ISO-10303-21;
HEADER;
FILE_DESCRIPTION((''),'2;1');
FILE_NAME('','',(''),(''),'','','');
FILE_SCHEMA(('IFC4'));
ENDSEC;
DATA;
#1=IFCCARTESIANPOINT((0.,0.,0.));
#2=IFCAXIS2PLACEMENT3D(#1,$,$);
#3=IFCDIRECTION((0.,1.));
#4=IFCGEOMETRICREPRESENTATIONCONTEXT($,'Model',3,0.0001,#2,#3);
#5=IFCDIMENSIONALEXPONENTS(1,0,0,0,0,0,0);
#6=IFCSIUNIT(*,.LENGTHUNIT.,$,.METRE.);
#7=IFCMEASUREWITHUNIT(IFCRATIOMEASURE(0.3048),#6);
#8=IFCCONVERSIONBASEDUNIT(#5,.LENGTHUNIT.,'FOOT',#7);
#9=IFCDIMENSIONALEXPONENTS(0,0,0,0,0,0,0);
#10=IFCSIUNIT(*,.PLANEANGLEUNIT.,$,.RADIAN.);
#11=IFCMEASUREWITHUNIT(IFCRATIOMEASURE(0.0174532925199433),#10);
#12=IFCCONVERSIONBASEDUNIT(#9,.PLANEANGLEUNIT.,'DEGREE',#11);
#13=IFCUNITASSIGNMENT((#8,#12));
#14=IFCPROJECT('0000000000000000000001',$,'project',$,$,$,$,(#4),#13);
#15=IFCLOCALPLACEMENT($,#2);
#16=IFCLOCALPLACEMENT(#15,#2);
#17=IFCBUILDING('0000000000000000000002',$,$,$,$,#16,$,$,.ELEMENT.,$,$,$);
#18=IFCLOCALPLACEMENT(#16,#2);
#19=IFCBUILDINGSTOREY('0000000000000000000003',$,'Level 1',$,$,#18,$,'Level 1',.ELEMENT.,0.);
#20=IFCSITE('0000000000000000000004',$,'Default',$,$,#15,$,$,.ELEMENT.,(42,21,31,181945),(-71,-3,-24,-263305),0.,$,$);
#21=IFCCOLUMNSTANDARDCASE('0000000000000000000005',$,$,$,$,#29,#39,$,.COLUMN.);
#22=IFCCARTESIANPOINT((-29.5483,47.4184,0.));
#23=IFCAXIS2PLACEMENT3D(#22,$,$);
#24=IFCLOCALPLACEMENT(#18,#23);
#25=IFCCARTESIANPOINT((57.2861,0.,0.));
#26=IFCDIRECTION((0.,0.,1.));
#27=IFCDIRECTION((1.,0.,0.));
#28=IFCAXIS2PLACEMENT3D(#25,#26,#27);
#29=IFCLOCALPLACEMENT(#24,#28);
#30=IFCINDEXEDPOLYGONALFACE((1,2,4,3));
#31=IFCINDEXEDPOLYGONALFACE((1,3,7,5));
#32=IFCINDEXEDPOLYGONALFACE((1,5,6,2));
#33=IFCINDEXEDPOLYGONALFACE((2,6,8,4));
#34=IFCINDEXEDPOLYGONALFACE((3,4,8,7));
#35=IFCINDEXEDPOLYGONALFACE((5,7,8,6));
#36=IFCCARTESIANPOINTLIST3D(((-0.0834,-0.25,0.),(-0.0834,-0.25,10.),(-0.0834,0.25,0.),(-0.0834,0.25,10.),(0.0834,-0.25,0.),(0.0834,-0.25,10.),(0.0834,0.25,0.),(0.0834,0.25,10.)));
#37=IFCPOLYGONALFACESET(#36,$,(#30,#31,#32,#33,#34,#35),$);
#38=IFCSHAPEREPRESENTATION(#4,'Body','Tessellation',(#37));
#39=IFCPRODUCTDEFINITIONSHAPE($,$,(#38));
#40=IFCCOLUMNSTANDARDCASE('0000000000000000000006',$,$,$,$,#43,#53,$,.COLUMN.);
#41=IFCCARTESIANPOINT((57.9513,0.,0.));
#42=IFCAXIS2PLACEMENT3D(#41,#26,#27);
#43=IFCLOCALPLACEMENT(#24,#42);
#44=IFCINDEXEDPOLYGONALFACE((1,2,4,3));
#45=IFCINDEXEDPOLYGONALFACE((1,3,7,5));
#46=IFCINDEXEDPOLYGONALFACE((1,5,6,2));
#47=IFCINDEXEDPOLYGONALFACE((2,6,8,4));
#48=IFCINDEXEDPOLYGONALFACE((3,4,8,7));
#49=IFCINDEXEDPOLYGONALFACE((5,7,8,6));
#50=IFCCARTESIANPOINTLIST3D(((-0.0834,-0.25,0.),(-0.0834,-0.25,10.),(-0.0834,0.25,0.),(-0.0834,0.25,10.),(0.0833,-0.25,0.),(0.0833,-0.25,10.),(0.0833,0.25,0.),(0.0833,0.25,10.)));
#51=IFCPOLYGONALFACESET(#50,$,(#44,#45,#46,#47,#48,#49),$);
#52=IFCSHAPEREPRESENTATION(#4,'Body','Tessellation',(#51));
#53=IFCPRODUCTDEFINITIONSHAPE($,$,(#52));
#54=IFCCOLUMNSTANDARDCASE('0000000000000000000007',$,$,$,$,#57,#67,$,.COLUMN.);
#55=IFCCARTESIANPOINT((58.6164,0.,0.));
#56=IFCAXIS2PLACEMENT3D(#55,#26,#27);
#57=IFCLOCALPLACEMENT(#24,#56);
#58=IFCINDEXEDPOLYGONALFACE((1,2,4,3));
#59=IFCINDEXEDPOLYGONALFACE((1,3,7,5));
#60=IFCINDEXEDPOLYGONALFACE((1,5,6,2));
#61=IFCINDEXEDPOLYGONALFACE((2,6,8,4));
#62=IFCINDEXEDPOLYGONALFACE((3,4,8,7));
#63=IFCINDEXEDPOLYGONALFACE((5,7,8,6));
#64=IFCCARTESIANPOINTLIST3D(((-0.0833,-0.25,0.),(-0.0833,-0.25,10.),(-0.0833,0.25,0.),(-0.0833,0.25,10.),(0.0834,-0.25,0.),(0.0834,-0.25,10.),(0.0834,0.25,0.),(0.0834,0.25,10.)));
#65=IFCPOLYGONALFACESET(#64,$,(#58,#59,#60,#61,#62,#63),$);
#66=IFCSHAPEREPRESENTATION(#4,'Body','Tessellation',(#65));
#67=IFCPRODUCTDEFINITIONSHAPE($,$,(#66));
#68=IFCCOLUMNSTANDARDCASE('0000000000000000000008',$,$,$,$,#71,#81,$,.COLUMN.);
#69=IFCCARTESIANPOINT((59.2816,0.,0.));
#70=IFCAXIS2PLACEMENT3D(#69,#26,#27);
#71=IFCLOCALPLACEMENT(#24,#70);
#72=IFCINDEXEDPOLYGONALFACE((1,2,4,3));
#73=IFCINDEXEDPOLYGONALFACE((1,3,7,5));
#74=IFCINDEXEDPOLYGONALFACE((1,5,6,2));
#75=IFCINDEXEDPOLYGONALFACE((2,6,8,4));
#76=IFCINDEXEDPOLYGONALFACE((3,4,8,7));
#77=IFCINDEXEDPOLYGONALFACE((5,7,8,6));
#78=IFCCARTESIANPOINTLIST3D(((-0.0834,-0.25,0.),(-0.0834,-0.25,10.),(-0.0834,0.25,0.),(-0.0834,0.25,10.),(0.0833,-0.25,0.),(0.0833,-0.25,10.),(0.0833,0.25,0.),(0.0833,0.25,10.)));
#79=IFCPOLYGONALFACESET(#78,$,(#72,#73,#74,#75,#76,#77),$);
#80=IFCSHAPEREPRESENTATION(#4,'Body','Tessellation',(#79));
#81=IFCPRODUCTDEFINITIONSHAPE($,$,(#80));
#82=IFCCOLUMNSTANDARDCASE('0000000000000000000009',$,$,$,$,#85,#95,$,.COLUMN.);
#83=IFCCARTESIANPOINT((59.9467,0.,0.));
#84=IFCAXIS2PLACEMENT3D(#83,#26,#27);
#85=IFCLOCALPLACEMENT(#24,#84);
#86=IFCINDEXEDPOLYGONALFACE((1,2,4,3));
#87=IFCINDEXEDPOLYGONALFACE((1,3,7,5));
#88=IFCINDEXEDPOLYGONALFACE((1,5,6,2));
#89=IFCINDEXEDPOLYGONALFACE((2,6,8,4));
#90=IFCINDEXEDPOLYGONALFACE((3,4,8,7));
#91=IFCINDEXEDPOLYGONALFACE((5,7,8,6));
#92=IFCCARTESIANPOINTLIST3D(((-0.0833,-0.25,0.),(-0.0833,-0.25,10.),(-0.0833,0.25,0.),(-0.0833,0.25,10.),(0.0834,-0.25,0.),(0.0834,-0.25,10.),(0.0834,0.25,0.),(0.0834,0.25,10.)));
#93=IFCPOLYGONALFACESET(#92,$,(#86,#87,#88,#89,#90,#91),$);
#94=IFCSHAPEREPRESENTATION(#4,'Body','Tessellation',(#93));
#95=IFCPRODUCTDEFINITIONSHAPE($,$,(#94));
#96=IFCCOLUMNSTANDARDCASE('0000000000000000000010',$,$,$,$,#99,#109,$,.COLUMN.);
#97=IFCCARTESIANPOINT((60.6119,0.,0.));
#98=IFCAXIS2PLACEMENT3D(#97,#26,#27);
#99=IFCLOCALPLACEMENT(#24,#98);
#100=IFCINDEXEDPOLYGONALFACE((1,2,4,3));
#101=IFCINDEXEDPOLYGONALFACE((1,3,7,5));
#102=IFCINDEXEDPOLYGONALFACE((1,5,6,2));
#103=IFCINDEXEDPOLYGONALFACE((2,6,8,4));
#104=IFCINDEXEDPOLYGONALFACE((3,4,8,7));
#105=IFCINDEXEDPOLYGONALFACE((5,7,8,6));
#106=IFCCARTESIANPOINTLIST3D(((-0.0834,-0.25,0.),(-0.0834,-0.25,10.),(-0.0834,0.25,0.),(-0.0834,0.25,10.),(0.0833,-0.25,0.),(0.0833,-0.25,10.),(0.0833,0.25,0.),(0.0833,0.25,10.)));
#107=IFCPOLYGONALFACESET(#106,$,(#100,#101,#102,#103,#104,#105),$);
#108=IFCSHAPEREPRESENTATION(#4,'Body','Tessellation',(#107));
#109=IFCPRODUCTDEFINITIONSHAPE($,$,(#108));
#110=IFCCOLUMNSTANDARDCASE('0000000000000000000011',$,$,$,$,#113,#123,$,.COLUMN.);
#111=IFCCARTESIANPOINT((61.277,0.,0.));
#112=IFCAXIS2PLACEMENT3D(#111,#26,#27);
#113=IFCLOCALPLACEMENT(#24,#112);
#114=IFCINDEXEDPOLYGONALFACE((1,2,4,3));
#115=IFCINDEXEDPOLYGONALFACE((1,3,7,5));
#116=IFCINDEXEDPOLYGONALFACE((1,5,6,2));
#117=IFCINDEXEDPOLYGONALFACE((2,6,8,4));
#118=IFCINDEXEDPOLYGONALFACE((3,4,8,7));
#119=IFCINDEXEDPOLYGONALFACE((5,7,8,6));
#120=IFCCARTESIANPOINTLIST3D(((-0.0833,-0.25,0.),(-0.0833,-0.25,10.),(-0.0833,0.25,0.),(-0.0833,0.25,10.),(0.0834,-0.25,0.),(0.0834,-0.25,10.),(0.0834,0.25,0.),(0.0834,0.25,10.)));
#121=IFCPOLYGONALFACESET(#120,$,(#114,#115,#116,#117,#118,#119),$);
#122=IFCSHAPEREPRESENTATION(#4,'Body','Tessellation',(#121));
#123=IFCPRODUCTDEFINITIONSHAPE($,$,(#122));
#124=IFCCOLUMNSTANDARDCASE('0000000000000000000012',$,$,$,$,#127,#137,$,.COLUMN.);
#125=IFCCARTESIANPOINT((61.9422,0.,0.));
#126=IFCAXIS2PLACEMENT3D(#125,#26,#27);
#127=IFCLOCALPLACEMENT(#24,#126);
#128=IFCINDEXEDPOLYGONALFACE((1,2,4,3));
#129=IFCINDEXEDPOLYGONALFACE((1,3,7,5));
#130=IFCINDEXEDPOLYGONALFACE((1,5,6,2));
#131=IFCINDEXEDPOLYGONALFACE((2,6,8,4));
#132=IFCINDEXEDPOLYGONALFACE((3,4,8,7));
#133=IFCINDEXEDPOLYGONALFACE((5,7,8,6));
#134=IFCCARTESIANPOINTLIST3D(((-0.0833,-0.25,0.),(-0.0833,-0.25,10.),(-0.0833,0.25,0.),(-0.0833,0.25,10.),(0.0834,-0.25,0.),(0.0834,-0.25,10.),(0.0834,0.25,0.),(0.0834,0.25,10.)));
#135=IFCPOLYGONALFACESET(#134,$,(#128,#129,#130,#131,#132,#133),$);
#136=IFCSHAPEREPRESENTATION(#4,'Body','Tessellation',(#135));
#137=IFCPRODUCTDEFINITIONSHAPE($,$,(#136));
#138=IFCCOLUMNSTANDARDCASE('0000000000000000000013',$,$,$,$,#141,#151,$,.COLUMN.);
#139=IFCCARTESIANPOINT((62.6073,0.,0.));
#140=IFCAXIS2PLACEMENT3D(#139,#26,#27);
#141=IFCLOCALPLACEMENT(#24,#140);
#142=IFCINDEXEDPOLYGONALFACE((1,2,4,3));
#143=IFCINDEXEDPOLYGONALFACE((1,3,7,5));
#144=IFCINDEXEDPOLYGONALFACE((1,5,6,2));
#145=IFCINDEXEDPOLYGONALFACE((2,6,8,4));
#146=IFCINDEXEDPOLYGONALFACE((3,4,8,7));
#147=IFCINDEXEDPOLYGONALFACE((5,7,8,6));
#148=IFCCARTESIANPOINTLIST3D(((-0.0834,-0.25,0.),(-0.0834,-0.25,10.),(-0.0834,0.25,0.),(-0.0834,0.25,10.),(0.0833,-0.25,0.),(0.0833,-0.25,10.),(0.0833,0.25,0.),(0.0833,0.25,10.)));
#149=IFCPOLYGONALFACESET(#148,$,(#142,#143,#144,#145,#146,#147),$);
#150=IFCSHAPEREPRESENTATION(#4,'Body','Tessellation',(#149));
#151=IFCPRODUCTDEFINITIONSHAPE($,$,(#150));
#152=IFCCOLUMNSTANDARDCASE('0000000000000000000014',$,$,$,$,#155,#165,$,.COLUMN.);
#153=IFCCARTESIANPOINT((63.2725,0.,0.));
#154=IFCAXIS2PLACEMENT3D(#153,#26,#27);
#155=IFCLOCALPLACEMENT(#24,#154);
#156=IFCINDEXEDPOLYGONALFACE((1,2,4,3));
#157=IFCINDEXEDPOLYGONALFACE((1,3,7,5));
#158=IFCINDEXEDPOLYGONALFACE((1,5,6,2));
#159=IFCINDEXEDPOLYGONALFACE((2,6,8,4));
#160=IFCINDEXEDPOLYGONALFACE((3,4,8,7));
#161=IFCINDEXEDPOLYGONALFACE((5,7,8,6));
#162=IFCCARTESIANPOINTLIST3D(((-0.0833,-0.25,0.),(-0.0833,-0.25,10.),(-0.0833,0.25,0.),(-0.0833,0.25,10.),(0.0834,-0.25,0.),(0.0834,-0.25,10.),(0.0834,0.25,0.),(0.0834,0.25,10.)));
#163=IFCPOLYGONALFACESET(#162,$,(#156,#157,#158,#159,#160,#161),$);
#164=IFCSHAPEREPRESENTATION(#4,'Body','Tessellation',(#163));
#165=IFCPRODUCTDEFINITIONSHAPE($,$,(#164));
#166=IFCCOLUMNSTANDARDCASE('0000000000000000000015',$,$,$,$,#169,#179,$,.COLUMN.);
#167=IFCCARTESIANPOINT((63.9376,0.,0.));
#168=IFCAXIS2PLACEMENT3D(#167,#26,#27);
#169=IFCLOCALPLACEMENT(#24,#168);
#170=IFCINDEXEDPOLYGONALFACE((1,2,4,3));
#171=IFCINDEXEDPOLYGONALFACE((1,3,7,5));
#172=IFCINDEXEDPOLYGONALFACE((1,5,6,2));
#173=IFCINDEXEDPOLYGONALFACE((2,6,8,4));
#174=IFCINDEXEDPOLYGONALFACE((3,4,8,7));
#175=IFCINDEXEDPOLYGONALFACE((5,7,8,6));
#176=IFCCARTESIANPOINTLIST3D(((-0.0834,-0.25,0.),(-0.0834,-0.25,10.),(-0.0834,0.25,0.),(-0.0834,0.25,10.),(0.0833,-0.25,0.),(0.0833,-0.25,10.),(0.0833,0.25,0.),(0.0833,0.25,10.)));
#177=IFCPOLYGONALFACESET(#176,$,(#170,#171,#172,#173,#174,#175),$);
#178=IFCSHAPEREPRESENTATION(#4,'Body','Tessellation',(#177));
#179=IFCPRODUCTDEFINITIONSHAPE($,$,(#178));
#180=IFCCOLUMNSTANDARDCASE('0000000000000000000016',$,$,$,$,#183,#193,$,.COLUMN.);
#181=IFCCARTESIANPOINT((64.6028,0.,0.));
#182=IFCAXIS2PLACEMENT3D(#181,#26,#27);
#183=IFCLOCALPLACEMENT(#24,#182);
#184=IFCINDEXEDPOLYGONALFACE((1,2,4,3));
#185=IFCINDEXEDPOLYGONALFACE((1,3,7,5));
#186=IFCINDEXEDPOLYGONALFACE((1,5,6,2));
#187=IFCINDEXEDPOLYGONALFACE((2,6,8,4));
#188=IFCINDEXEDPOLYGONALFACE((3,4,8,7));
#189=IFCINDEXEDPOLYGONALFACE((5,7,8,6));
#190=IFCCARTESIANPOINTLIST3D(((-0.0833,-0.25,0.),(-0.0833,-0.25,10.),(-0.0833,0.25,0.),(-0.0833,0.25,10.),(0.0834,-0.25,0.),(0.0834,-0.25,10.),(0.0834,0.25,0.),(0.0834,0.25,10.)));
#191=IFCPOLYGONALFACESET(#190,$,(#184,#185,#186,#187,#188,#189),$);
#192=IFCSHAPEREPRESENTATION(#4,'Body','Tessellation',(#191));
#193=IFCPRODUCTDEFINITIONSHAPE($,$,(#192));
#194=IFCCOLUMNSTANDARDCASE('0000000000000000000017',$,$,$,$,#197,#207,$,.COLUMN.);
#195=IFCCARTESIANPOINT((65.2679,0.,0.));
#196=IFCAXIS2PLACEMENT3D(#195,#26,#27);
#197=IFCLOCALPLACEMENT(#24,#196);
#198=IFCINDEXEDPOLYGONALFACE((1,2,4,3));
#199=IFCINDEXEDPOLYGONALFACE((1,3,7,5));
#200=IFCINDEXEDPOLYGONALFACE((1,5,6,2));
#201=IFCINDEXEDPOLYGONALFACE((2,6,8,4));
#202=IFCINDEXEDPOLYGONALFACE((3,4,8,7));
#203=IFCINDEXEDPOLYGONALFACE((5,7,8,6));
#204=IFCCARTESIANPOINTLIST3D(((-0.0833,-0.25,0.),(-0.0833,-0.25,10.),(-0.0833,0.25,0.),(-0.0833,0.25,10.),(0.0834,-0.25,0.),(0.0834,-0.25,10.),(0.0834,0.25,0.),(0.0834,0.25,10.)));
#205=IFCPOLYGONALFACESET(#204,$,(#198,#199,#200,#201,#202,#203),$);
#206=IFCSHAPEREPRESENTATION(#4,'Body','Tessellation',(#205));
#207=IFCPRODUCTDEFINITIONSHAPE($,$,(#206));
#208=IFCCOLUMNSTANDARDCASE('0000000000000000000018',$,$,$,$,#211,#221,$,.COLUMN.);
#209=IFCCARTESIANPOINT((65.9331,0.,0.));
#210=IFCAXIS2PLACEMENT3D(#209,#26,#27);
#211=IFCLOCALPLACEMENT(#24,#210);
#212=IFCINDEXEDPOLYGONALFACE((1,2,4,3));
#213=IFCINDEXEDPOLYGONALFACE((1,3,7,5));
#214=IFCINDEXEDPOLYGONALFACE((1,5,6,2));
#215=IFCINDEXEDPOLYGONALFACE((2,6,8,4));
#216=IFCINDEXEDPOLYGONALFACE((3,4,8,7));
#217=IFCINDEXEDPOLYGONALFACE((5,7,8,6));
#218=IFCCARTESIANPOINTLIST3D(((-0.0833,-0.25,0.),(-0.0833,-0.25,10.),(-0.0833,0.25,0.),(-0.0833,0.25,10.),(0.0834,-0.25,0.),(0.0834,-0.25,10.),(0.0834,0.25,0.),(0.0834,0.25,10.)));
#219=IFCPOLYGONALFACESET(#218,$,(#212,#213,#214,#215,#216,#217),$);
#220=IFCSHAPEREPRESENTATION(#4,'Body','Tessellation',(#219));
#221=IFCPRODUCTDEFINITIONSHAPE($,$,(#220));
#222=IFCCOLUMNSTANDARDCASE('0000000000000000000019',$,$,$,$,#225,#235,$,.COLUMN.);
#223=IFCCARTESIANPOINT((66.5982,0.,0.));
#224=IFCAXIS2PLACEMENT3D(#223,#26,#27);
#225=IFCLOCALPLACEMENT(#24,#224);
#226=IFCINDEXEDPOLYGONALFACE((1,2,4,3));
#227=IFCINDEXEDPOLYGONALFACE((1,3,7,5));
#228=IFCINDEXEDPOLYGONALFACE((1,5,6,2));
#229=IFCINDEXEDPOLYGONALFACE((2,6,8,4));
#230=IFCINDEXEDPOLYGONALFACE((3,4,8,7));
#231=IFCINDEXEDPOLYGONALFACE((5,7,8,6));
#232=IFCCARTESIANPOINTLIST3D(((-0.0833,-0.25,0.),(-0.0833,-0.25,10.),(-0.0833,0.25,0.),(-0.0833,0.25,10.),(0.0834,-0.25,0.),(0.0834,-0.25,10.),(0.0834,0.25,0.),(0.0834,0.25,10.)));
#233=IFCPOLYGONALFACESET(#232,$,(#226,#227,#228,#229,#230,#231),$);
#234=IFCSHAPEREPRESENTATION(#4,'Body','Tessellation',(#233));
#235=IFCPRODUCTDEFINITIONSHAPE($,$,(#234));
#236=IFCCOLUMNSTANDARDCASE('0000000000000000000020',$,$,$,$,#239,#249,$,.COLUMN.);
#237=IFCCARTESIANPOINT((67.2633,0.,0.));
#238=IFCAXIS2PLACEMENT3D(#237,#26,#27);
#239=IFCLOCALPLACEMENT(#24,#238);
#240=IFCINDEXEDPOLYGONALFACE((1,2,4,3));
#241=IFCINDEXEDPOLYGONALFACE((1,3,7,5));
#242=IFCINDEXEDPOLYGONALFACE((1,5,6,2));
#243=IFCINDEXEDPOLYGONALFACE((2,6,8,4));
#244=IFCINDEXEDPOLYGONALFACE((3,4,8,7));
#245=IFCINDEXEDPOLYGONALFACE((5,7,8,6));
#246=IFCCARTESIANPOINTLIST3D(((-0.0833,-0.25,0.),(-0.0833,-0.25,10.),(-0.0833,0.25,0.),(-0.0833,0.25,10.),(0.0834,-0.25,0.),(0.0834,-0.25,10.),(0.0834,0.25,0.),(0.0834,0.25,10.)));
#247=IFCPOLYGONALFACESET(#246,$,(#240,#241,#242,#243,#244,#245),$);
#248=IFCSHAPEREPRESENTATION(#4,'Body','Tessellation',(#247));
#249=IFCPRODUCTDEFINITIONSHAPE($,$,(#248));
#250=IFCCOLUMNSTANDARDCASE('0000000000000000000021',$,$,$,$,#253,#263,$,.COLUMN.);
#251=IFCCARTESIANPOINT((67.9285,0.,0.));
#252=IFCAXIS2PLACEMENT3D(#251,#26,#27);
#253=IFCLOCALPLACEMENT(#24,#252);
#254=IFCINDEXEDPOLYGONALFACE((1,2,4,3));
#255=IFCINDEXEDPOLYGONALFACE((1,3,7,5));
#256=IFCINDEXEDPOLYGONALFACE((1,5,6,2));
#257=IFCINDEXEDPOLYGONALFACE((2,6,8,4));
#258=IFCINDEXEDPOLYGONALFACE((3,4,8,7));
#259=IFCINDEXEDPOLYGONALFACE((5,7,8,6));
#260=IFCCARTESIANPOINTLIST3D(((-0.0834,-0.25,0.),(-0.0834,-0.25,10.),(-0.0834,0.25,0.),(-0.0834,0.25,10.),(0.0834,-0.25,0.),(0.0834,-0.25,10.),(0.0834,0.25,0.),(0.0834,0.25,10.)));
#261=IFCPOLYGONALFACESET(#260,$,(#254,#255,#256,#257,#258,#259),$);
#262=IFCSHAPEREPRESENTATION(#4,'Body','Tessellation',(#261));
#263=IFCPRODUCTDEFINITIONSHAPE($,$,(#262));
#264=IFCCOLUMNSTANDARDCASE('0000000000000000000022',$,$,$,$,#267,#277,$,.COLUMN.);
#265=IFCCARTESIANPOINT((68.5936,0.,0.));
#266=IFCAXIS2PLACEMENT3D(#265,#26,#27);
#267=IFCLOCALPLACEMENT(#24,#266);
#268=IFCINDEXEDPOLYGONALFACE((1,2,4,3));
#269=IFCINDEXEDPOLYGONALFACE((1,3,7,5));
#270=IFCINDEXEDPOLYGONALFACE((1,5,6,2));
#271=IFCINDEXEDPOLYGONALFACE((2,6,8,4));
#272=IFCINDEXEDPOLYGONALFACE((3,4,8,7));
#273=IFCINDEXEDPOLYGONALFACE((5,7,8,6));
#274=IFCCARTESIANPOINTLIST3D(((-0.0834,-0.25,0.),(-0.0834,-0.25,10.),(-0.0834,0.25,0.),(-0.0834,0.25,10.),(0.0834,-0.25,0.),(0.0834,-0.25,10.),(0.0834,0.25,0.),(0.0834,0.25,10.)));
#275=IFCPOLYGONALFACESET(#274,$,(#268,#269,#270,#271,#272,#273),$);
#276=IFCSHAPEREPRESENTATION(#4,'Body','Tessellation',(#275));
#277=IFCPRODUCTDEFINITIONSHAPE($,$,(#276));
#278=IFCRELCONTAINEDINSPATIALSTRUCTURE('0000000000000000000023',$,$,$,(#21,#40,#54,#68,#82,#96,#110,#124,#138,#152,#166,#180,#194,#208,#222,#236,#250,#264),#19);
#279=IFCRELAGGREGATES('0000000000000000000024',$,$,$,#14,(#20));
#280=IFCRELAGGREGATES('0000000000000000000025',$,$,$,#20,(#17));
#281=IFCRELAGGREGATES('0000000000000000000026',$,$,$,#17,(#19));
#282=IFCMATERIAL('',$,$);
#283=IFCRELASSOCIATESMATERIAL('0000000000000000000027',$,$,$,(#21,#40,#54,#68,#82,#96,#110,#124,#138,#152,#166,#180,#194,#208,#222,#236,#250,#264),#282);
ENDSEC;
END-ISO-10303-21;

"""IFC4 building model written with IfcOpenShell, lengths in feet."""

from ifc_helpers import new_model, entity, si_unit, converted_unit, direction, frame, origin, place, context, project, spatial, rectangle, extrude, material, element, save


model = new_model("IFC4")

# Units and contexts
model_context = context("Model", 3, precision=0.0001, world=origin(), true_north=direction((0.0, 1.0)))
ifc_project = project(units=[converted_unit("LENGTHUNIT", "FOOT", entity("IfcRatioMeasure", 0.3048), si_unit("LENGTHUNIT", "METRE"), dimensions=[1, 0, 0, 0, 0, 0, 0]), converted_unit("PLANEANGLEUNIT", "DEGREE", entity("IfcRatioMeasure", 0.0174532925199433), si_unit("PLANEANGLEUNIT", "RADIAN"), dimensions=[0, 0, 0, 0, 0, 0, 0])], contexts=[model_context])

# Site, building, storey
site_placement = place(None, origin())
site = spatial("IfcSite", under=ifc_project, at=site_placement, Name="Default", CompositionType="ELEMENT", RefLatitude=(42, 21, 31, 181945), RefLongitude=(-71, -3, -24, -263305), RefElevation=0.0)
building_placement = place(site_placement, origin())
building = spatial("IfcBuilding", under=site, at=building_placement, CompositionType="ELEMENT")
storey_placement = place(building_placement, origin())
storey = spatial("IfcBuildingStorey", under=building, at=storey_placement, Name="Level 1", LongName="Level 1", CompositionType="ELEMENT", Elevation=0.0)

# Columns
ifc_material_1 = material(Name="")
placement = place(storey_placement, frame((-29.5483, 47.4184, 0.0)))
for number, where, z_axis, x_axis in (
    (1, (57.2861, 0.0, 0.0), (0.0, 0.0, 1.0), (1.0, 0.0, 0.0)),
    (2, (57.9513, 0.0, 0.0), (0.0, 0.0, 1.0), (1.0, 0.0, 0.0)),
    (3, (58.6164, 0.0, 0.0), (0.0, 0.0, 1.0), (1.0, 0.0, 0.0)),
    (4, (59.2816, 0.0, 0.0), (0.0, 0.0, 1.0), (1.0, 0.0, 0.0)),
    (5, (59.9467, 0.0, 0.0), (0.0, 0.0, 1.0), (1.0, 0.0, 0.0)),
    (6, (60.6119, 0.0, 0.0), (0.0, 0.0, 1.0), (1.0, 0.0, 0.0)),
    (7, (61.277, 0.0, 0.0), (0.0, 0.0, 1.0), (1.0, 0.0, 0.0)),
    (8, (61.9422, 0.0, 0.0), (0.0, 0.0, 1.0), (1.0, 0.0, 0.0)),
    (9, (62.6073, 0.0, 0.0), (0.0, 0.0, 1.0), (1.0, 0.0, 0.0)),
    (10, (63.2725, 0.0, 0.0), (0.0, 0.0, 1.0), (1.0, 0.0, 0.0)),
    (11, (63.9376, 0.0, 0.0), (0.0, 0.0, 1.0), (1.0, 0.0, 0.0)),
    (12, (64.6028, 0.0, 0.0), (0.0, 0.0, 1.0), (1.0, 0.0, 0.0)),
    (13, (65.2679, 0.0, 0.0), (0.0, 0.0, 1.0), (1.0, 0.0, 0.0)),
    (14, (65.9331, 0.0, 0.0), (0.0, 0.0, 1.0), (1.0, 0.0, 0.0)),
    (15, (66.5982, 0.0, 0.0), (0.0, 0.0, 1.0), (1.0, 0.0, 0.0)),
    (16, (67.2633, 0.0, 0.0), (0.0, 0.0, 1.0), (1.0, 0.0, 0.0)),
    (17, (67.9285, 0.0, 0.0), (0.0, 0.0, 1.0), (1.0, 0.0, 0.0)),
    (18, (68.5936, 0.0, 0.0), (0.0, 0.0, 1.0), (1.0, 0.0, 0.0)),
):
    element("IfcColumnStandardCase", number, at=place(placement, frame(where, z_axis=z_axis, x_axis=x_axis)), inside=storey, material=ifc_material_1, PredefinedType="COLUMN", context=model_context, shape_type="SweptSolid", body=[
        extrude(rectangle(XDim=0.1667, YDim=0.5), origin(), (0.0, 0.0, 1.0), 10.0),
    ])

save(model, "model.ifc")
